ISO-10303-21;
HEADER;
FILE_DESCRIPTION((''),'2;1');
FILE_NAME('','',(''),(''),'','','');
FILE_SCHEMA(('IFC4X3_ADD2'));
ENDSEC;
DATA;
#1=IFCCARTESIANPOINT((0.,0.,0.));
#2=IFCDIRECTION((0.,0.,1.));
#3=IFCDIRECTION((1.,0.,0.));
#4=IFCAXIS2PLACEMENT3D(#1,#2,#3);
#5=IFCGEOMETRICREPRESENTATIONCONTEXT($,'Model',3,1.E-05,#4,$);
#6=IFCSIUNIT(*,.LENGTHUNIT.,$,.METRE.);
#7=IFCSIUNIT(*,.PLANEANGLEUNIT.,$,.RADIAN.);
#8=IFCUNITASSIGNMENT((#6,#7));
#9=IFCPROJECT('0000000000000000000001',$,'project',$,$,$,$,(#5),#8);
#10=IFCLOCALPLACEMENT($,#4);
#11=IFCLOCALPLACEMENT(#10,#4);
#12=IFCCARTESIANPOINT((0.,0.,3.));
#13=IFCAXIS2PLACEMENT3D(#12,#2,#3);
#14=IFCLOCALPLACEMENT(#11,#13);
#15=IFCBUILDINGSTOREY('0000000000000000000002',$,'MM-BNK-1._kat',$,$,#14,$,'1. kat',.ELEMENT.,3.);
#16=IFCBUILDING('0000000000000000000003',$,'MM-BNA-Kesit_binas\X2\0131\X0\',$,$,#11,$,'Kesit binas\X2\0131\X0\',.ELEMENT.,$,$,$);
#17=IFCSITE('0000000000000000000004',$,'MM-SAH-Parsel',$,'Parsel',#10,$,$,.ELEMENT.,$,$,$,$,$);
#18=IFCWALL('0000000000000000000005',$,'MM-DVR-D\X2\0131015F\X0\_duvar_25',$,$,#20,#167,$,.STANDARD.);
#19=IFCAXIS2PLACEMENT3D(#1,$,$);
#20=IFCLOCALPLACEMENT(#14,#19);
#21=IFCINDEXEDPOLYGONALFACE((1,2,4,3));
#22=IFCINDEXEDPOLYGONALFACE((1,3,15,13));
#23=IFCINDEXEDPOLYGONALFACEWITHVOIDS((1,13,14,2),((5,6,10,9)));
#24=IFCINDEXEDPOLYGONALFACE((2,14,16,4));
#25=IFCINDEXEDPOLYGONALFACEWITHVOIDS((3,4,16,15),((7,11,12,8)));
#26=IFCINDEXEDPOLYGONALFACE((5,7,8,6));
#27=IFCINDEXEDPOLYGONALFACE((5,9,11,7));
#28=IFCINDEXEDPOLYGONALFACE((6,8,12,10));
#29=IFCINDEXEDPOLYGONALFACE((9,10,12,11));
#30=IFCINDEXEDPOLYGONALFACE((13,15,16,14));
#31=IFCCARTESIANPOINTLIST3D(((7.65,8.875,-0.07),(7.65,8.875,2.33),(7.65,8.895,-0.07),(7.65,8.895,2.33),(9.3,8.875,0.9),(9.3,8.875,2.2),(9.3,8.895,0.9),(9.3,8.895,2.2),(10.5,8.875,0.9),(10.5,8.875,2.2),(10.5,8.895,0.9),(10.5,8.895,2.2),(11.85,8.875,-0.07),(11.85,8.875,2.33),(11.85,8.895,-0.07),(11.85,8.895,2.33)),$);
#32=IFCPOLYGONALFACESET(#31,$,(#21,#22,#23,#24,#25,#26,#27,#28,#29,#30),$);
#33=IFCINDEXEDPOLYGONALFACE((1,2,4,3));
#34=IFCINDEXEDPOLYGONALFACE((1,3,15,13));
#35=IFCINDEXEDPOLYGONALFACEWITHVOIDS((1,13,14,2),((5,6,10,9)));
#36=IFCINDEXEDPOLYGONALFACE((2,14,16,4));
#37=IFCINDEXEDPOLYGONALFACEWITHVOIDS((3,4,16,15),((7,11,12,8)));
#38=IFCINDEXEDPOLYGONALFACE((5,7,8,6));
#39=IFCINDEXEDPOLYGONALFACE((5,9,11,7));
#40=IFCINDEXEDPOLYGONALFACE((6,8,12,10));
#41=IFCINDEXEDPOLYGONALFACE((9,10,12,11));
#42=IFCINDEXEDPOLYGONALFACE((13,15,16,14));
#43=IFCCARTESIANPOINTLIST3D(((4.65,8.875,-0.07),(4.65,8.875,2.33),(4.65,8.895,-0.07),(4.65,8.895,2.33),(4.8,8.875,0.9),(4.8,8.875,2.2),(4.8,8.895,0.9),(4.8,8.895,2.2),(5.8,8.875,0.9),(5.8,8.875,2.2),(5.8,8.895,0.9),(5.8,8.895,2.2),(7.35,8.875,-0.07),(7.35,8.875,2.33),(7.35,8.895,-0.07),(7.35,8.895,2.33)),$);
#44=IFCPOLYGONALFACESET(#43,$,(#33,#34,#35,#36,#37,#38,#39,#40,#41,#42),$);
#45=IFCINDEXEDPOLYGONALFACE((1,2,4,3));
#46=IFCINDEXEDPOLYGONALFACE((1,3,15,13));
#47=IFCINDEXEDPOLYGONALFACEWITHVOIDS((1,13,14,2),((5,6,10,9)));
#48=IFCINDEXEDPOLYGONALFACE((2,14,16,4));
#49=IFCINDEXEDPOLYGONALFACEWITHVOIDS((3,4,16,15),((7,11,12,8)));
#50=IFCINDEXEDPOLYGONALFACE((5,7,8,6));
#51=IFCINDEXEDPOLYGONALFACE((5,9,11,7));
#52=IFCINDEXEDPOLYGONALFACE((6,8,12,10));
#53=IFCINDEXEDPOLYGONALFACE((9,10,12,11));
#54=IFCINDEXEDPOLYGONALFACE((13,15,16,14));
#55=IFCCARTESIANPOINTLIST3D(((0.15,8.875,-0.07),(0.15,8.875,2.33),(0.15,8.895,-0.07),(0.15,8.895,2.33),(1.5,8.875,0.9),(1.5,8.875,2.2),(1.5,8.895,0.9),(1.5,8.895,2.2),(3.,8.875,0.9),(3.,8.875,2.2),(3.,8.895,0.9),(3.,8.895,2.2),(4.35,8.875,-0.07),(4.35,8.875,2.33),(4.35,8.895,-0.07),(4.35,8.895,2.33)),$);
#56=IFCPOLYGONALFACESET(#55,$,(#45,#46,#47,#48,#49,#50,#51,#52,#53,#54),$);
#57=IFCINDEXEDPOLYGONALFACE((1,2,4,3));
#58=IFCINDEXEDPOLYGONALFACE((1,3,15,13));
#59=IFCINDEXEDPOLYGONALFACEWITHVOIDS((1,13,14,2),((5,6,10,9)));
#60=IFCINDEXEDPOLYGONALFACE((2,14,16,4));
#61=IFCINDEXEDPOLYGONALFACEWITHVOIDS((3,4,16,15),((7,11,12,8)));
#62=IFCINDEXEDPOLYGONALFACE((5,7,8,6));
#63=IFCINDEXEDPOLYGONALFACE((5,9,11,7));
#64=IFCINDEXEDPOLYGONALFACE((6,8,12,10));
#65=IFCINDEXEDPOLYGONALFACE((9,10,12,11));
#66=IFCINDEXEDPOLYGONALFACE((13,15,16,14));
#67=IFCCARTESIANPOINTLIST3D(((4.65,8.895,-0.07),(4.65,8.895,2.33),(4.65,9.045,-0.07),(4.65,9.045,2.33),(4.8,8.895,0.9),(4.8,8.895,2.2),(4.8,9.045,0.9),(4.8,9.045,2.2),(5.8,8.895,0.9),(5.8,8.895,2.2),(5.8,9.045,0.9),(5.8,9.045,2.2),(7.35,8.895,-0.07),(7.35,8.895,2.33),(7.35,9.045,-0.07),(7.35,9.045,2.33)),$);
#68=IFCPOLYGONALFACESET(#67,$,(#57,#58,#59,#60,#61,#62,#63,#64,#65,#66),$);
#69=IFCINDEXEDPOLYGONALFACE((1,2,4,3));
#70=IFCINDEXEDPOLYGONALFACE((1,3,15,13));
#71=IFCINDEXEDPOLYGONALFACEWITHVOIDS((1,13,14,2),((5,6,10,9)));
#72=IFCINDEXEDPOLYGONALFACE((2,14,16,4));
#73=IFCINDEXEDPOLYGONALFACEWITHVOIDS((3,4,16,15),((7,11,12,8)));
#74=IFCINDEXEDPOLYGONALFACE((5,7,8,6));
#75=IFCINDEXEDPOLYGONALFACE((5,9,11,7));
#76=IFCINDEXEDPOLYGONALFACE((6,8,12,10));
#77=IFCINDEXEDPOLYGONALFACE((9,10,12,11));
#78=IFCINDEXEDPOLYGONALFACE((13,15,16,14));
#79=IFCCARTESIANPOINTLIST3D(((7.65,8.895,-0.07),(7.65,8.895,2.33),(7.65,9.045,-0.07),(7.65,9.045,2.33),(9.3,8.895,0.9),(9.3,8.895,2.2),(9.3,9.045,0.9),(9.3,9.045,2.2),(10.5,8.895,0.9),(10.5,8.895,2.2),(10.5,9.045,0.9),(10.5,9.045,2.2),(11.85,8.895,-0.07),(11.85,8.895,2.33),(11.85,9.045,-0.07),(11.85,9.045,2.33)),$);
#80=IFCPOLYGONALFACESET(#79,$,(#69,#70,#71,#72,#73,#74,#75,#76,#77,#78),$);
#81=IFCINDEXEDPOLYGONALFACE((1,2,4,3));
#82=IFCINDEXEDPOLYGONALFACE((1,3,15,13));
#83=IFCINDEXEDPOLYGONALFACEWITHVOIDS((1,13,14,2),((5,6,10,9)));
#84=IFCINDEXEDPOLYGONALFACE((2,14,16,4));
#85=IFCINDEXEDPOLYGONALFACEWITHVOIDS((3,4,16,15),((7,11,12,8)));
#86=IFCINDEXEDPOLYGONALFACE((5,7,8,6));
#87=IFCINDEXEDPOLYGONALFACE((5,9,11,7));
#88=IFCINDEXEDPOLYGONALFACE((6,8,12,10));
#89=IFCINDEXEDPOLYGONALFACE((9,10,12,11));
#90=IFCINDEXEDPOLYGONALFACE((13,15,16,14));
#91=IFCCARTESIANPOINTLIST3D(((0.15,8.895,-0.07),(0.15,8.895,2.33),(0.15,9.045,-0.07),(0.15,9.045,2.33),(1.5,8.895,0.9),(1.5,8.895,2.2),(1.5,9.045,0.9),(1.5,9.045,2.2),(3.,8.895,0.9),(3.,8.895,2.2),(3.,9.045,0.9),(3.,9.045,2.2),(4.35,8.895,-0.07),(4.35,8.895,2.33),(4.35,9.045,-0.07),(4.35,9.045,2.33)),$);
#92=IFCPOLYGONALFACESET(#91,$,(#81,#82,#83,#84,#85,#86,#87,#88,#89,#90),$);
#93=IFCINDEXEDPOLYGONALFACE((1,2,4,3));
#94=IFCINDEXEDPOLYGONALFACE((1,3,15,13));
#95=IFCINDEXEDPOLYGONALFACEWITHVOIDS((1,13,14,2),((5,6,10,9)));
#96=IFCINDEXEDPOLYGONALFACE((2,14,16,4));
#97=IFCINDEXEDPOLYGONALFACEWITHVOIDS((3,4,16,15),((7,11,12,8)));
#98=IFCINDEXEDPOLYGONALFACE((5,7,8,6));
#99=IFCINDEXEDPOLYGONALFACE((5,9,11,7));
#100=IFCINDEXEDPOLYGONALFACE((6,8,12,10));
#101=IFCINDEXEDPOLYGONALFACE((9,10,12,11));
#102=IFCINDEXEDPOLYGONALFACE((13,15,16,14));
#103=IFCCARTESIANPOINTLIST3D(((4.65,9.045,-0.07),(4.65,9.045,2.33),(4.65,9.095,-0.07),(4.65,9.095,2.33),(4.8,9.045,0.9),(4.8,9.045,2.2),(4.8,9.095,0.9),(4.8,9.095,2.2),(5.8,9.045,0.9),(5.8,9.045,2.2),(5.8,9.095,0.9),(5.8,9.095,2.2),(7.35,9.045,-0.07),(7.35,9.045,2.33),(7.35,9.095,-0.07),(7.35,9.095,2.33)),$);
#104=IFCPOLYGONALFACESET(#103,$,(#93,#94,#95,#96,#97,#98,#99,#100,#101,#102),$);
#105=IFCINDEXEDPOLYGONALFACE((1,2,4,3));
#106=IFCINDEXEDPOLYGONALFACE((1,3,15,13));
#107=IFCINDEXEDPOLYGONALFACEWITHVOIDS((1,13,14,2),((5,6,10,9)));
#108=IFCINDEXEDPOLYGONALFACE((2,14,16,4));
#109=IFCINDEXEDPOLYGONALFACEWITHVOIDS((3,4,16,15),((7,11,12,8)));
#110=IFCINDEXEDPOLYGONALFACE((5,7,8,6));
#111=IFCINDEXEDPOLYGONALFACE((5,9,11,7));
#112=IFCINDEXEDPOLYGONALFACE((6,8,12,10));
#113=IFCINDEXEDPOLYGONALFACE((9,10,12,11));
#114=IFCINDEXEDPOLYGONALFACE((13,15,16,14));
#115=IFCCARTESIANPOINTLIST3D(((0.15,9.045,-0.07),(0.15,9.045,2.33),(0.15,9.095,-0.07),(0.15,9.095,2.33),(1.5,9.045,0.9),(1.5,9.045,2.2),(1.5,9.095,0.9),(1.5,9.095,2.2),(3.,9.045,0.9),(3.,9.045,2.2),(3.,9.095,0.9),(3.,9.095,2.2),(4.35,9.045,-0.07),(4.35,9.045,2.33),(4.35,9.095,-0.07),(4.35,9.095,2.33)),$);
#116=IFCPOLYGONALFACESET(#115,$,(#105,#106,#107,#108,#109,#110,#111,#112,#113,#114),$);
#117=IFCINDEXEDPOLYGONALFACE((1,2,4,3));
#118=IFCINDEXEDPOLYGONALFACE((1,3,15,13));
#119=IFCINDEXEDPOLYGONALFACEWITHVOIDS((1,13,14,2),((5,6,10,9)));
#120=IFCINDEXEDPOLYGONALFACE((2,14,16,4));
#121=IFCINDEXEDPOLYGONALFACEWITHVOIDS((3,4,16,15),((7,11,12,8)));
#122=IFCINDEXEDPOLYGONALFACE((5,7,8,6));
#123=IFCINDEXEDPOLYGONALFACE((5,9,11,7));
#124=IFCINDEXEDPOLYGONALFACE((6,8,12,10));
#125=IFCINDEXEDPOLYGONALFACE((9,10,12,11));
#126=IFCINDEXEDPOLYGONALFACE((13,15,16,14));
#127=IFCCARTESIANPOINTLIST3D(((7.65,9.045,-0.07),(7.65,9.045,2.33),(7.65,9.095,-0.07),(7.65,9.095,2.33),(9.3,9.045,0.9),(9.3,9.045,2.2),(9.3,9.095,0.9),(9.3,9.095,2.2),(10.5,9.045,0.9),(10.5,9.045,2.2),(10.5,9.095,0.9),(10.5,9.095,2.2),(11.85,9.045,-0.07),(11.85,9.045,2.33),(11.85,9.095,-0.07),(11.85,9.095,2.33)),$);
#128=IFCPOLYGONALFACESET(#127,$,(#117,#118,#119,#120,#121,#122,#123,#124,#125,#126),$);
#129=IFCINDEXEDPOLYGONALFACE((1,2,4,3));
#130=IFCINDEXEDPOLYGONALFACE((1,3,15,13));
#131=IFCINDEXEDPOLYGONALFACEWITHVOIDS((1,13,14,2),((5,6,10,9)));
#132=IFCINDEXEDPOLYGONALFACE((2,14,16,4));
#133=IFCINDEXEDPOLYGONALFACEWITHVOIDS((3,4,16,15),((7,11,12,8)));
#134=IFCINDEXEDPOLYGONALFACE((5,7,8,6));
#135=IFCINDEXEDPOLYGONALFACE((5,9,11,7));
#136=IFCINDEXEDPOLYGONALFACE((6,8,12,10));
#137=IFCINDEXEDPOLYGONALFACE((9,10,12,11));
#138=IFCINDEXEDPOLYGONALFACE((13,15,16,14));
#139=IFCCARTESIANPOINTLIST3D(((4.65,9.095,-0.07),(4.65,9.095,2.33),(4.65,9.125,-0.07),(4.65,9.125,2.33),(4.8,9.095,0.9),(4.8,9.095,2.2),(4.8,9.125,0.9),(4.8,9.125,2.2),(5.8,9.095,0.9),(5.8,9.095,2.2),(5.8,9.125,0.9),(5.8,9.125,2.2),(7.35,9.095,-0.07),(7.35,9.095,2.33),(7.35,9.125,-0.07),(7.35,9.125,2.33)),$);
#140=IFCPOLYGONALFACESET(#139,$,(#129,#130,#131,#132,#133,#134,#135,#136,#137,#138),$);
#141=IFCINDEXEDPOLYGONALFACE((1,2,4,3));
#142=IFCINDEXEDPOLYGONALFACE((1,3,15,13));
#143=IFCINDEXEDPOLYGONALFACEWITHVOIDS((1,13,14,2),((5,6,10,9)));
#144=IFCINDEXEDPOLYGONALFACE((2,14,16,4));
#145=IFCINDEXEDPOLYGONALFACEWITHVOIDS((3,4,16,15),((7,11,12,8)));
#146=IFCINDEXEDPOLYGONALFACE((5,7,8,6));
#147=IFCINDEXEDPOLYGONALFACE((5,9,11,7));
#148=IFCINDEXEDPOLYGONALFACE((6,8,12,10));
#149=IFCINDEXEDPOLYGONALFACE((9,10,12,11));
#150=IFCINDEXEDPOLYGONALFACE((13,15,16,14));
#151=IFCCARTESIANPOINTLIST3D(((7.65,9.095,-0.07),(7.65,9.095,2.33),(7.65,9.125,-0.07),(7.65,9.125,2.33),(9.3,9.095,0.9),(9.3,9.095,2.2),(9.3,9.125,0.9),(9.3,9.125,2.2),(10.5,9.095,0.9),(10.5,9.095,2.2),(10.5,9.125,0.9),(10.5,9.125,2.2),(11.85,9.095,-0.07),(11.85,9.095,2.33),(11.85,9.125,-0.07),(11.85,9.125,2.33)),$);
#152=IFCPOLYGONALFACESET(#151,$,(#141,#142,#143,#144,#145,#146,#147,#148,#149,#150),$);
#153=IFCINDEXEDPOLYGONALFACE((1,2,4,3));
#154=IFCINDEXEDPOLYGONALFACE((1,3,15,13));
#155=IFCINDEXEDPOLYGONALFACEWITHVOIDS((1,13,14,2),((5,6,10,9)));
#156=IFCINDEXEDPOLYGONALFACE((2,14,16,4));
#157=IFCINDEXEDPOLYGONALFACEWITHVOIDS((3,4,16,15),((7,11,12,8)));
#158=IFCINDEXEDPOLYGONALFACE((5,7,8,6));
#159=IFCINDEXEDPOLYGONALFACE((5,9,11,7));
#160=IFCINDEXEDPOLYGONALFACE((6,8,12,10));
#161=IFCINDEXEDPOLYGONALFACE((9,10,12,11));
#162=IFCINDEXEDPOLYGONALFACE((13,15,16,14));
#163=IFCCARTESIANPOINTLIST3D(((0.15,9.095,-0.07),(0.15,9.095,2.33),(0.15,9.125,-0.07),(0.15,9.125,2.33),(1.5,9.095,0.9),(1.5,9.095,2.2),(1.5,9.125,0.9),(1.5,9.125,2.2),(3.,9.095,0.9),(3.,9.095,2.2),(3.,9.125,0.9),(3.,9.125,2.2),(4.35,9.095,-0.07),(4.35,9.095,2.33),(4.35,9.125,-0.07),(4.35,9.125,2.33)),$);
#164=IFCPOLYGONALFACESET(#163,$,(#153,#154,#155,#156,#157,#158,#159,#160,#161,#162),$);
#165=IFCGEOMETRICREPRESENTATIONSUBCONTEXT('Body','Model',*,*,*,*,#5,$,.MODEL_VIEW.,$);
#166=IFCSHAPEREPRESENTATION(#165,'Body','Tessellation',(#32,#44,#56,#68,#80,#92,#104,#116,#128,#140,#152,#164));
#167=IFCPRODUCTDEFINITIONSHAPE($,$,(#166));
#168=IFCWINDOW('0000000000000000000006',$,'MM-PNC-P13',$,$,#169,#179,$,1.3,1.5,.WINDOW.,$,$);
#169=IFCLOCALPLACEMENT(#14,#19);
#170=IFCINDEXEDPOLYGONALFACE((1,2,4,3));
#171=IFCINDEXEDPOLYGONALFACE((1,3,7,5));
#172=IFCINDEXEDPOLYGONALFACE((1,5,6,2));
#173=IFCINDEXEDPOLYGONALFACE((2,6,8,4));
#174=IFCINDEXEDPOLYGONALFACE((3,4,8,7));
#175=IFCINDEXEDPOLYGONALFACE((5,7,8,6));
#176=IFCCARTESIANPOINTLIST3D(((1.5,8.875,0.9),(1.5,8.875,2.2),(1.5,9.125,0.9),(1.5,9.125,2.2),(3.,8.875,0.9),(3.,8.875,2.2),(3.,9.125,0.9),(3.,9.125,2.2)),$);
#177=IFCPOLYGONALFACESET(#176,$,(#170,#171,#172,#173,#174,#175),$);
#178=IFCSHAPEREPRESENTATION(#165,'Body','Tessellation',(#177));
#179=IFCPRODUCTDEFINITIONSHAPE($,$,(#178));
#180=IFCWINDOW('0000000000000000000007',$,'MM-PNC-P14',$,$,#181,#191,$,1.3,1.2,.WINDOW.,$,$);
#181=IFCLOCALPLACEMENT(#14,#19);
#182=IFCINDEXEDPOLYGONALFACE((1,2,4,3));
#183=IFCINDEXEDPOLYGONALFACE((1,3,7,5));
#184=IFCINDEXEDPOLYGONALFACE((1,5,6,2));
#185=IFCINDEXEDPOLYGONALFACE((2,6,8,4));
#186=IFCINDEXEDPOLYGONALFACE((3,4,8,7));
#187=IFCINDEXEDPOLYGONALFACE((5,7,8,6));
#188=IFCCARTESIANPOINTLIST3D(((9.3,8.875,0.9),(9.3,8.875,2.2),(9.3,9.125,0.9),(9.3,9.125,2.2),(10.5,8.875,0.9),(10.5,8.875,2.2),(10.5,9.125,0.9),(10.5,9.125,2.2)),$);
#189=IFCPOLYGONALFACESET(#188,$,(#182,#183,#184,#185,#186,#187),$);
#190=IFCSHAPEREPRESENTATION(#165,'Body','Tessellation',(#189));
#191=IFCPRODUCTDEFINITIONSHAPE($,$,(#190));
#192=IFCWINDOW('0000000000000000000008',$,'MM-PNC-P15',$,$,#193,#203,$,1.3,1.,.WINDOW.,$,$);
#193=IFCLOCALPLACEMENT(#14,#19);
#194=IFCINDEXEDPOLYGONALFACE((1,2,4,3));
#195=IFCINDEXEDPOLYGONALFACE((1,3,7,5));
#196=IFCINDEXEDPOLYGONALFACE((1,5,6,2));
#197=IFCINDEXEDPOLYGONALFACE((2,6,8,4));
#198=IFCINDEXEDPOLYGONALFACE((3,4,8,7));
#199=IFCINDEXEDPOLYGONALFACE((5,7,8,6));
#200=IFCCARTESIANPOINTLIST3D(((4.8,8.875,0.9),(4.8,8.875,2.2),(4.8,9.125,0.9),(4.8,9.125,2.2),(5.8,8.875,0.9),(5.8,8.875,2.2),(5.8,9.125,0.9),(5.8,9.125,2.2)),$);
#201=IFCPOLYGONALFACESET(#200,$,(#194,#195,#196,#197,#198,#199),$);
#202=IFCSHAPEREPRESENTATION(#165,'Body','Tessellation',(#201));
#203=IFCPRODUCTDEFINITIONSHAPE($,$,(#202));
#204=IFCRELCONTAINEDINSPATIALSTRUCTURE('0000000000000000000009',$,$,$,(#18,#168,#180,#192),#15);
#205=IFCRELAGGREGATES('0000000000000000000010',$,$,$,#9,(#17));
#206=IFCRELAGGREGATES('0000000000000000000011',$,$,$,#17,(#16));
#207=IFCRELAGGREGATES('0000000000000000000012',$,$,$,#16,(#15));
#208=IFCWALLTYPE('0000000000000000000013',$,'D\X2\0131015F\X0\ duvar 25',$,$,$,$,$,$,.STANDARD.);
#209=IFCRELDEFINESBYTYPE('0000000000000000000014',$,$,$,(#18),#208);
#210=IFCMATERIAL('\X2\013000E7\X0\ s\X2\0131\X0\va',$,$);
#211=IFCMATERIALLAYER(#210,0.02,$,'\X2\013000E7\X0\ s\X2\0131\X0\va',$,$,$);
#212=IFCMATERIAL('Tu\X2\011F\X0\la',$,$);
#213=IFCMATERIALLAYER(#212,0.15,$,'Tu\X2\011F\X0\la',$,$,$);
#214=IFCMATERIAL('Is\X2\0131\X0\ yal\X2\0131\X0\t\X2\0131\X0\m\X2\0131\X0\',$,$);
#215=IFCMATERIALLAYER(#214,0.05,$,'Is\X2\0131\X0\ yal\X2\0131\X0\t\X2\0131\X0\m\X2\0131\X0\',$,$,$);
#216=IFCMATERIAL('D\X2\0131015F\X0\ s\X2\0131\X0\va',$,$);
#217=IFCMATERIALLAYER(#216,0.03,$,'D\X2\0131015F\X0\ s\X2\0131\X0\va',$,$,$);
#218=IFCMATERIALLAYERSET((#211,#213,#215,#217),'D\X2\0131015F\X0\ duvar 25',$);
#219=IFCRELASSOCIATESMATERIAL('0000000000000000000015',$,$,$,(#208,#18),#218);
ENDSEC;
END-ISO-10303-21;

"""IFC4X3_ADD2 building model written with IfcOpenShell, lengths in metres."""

from ifc_helpers import new_model, si_unit, frame, origin_with_axes, place, context, subcontext, project, spatial, polyline, outline, extrude, material, layer, layer_set, type_object, element, fill, save


model = new_model("IFC4X3_ADD2")

# Units and contexts
model_context = context("Model", 3, precision=1e-05, world=origin_with_axes())
body_context = subcontext(model_context, "Body", "Model", "MODEL_VIEW")
ifc_project = project(units=[si_unit("LENGTHUNIT", "METRE"), si_unit("PLANEANGLEUNIT", "RADIAN")], contexts=[model_context])

# Site, building, storey
site_placement = place(None, origin_with_axes())
site = spatial("IfcSite", under=ifc_project, at=site_placement, Name="MM-SAH-Parsel", ObjectType="Parsel", CompositionType="ELEMENT")
building_placement = place(site_placement, origin_with_axes())
building = spatial("IfcBuilding", under=site, at=building_placement, Name="MM-BNA-Kesit_binası", LongName="Kesit binası", CompositionType="ELEMENT")
storey_placement = place(building_placement, frame((0.0, 0.0, 3.0), z_axis=(0.0, 0.0, 1.0), x_axis=(1.0, 0.0, 0.0)))
storey = spatial("IfcBuildingStorey", under=building, at=storey_placement, Name="MM-BNK-1._kat", LongName="1. kat", CompositionType="ELEMENT", Elevation=3.0)

# Shared definitions
ifc_material_1 = material(Name="İç sıva")
ifc_layer_1 = layer(ifc_material_1, 0.02, Name="İç sıva")
ifc_material_2 = material(Name="Tuğla")
ifc_layer_2 = layer(ifc_material_2, 0.15, Name="Tuğla")
ifc_material_3 = material(Name="Isı yalıtımı")
ifc_layer_3 = layer(ifc_material_3, 0.05, Name="Isı yalıtımı")
ifc_material_4 = material(Name="Dış sıva")
ifc_layer_4 = layer(ifc_material_4, 0.03, Name="Dış sıva")
ifc_layer_set_1 = layer_set([ifc_layer_1, ifc_layer_2, ifc_layer_3, ifc_layer_4], Name="Dış duvar 25")
wall_type_1 = type_object("IfcWallType", Name="Dış duvar 25", PredefinedType="STANDARD", material=ifc_layer_set_1)

# Wall, openings, windows
wall_1_placement = place(storey_placement, origin_with_axes())
wall_1 = element("IfcWall", 1, at=wall_1_placement, inside=storey, type_object=wall_type_1, material=ifc_layer_set_1, Name="MM-DVR-Dış_duvar_25", PredefinedType="STANDARD", context=body_context, shape_type="SweptSolid", body=[
    extrude(outline(polyline([(11.85, 8.895), (7.65, 8.895), (7.65, 8.875), (11.85, 8.875), (11.85, 8.895)])), frame((0.0, 0.0, -0.07)), (0.0, 0.0, 1.0), 2.4),
    extrude(outline(polyline([(7.35, 8.895), (4.65, 8.895), (4.65, 8.875), (7.35, 8.875), (7.35, 8.895)])), frame((0.0, 0.0, -0.07)), (0.0, 0.0, 1.0), 2.4),
    extrude(outline(polyline([(4.35, 8.895), (0.15, 8.895), (0.15, 8.875), (4.35, 8.875), (4.35, 8.895)])), frame((0.0, 0.0, -0.07)), (0.0, 0.0, 1.0), 2.4),
    extrude(outline(polyline([(7.35, 9.045), (4.65, 9.045), (4.65, 8.895), (7.35, 8.895), (7.35, 9.045)])), frame((0.0, 0.0, -0.07)), (0.0, 0.0, 1.0), 2.4),
    extrude(outline(polyline([(11.85, 9.045), (7.65, 9.045), (7.65, 8.895), (11.85, 8.895), (11.85, 9.045)])), frame((0.0, 0.0, -0.07)), (0.0, 0.0, 1.0), 2.4),
    extrude(outline(polyline([(4.35, 9.045), (0.15, 9.045), (0.15, 8.895), (4.35, 8.895), (4.35, 9.045)])), frame((0.0, 0.0, -0.07)), (0.0, 0.0, 1.0), 2.4),
    extrude(outline(polyline([(7.35, 9.095), (4.65, 9.095), (4.65, 9.045), (7.35, 9.045), (7.35, 9.095)])), frame((0.0, 0.0, -0.07)), (0.0, 0.0, 1.0), 2.4),
    extrude(outline(polyline([(4.35, 9.095), (0.15, 9.095), (0.15, 9.045), (4.35, 9.045), (4.35, 9.095)])), frame((0.0, 0.0, -0.07)), (0.0, 0.0, 1.0), 2.4),
    extrude(outline(polyline([(11.85, 9.095), (7.65, 9.095), (7.65, 9.045), (11.85, 9.045), (11.85, 9.095)])), frame((0.0, 0.0, -0.07)), (0.0, 0.0, 1.0), 2.4),
    extrude(outline(polyline([(7.35, 9.125), (4.65, 9.125), (4.65, 9.095), (7.35, 9.095), (7.35, 9.125)])), frame((0.0, 0.0, -0.07)), (0.0, 0.0, 1.0), 2.4),
    extrude(outline(polyline([(11.85, 9.125), (7.65, 9.125), (7.65, 9.095), (11.85, 9.095), (11.85, 9.125)])), frame((0.0, 0.0, -0.07)), (0.0, 0.0, 1.0), 2.4),
    extrude(outline(polyline([(4.35, 9.125), (0.15, 9.125), (0.15, 9.095), (4.35, 9.095), (4.35, 9.125)])), frame((0.0, 0.0, -0.07)), (0.0, 0.0, 1.0), 2.4),
])
opening_1_placement = place(storey_placement, origin_with_axes())
opening_1 = element("IfcOpeningElement", 2, at=opening_1_placement, cuts=wall_1, PredefinedType="OPENING", context=body_context, shape_type="SweptSolid", body=[
    extrude(outline(polyline([(3.0, 8.875), (1.5, 8.875), (1.5, 9.125), (3.0, 9.125), (3.0, 8.875)])), frame((0.0, 0.0, 0.9)), (0.0, 0.0, 1.0), 1.3),
])
opening_2_placement = place(storey_placement, origin_with_axes())
opening_2 = element("IfcOpeningElement", 3, at=opening_2_placement, cuts=wall_1, PredefinedType="OPENING", context=body_context, shape_type="SweptSolid", body=[
    extrude(outline(polyline([(10.5, 8.875), (9.3, 8.875), (9.3, 9.125), (10.5, 9.125), (10.5, 8.875)])), frame((0.0, 0.0, 0.9)), (0.0, 0.0, 1.0), 1.3),
])
opening_3_placement = place(storey_placement, origin_with_axes())
opening_3 = element("IfcOpeningElement", 4, at=opening_3_placement, cuts=wall_1, PredefinedType="OPENING", context=body_context, shape_type="SweptSolid", body=[
    extrude(outline(polyline([(5.8, 8.875), (4.8, 8.875), (4.8, 9.125), (5.8, 9.125), (5.8, 8.875)])), frame((0.0, 0.0, 0.9)), (0.0, 0.0, 1.0), 1.3),
])
window_1_placement = place(storey_placement, origin_with_axes())
window_1 = element("IfcWindow", 5, at=window_1_placement, inside=storey, Name="MM-PNC-P13", OverallHeight=1.3, OverallWidth=1.5, PredefinedType="WINDOW", context=body_context, shape_type="SweptSolid", body=[
    extrude(outline(polyline([(3.0, 8.875), (1.5, 8.875), (1.5, 9.125), (3.0, 9.125), (3.0, 8.875)])), frame((0.0, 0.0, 0.9)), (0.0, 0.0, 1.0), 1.3),
])
fill(opening_1, window_1)
window_2_placement = place(storey_placement, origin_with_axes())
window_2 = element("IfcWindow", 6, at=window_2_placement, inside=storey, Name="MM-PNC-P14", OverallHeight=1.3, OverallWidth=1.2, PredefinedType="WINDOW", context=body_context, shape_type="SweptSolid", body=[
    extrude(outline(polyline([(10.5, 8.875), (9.3, 8.875), (9.3, 9.125), (10.5, 9.125), (10.5, 8.875)])), frame((0.0, 0.0, 0.9)), (0.0, 0.0, 1.0), 1.3),
])
fill(opening_2, window_2)
window_3_placement = place(storey_placement, origin_with_axes())
window_3 = element("IfcWindow", 7, at=window_3_placement, inside=storey, Name="MM-PNC-P15", OverallHeight=1.3, OverallWidth=1.0, PredefinedType="WINDOW", context=body_context, shape_type="SweptSolid", body=[
    extrude(outline(polyline([(5.8, 8.875), (4.8, 8.875), (4.8, 9.125), (5.8, 9.125), (5.8, 8.875)])), frame((0.0, 0.0, 0.9)), (0.0, 0.0, 1.0), 1.3),
])
fill(opening_3, window_3)

save(model, "model.ifc")
